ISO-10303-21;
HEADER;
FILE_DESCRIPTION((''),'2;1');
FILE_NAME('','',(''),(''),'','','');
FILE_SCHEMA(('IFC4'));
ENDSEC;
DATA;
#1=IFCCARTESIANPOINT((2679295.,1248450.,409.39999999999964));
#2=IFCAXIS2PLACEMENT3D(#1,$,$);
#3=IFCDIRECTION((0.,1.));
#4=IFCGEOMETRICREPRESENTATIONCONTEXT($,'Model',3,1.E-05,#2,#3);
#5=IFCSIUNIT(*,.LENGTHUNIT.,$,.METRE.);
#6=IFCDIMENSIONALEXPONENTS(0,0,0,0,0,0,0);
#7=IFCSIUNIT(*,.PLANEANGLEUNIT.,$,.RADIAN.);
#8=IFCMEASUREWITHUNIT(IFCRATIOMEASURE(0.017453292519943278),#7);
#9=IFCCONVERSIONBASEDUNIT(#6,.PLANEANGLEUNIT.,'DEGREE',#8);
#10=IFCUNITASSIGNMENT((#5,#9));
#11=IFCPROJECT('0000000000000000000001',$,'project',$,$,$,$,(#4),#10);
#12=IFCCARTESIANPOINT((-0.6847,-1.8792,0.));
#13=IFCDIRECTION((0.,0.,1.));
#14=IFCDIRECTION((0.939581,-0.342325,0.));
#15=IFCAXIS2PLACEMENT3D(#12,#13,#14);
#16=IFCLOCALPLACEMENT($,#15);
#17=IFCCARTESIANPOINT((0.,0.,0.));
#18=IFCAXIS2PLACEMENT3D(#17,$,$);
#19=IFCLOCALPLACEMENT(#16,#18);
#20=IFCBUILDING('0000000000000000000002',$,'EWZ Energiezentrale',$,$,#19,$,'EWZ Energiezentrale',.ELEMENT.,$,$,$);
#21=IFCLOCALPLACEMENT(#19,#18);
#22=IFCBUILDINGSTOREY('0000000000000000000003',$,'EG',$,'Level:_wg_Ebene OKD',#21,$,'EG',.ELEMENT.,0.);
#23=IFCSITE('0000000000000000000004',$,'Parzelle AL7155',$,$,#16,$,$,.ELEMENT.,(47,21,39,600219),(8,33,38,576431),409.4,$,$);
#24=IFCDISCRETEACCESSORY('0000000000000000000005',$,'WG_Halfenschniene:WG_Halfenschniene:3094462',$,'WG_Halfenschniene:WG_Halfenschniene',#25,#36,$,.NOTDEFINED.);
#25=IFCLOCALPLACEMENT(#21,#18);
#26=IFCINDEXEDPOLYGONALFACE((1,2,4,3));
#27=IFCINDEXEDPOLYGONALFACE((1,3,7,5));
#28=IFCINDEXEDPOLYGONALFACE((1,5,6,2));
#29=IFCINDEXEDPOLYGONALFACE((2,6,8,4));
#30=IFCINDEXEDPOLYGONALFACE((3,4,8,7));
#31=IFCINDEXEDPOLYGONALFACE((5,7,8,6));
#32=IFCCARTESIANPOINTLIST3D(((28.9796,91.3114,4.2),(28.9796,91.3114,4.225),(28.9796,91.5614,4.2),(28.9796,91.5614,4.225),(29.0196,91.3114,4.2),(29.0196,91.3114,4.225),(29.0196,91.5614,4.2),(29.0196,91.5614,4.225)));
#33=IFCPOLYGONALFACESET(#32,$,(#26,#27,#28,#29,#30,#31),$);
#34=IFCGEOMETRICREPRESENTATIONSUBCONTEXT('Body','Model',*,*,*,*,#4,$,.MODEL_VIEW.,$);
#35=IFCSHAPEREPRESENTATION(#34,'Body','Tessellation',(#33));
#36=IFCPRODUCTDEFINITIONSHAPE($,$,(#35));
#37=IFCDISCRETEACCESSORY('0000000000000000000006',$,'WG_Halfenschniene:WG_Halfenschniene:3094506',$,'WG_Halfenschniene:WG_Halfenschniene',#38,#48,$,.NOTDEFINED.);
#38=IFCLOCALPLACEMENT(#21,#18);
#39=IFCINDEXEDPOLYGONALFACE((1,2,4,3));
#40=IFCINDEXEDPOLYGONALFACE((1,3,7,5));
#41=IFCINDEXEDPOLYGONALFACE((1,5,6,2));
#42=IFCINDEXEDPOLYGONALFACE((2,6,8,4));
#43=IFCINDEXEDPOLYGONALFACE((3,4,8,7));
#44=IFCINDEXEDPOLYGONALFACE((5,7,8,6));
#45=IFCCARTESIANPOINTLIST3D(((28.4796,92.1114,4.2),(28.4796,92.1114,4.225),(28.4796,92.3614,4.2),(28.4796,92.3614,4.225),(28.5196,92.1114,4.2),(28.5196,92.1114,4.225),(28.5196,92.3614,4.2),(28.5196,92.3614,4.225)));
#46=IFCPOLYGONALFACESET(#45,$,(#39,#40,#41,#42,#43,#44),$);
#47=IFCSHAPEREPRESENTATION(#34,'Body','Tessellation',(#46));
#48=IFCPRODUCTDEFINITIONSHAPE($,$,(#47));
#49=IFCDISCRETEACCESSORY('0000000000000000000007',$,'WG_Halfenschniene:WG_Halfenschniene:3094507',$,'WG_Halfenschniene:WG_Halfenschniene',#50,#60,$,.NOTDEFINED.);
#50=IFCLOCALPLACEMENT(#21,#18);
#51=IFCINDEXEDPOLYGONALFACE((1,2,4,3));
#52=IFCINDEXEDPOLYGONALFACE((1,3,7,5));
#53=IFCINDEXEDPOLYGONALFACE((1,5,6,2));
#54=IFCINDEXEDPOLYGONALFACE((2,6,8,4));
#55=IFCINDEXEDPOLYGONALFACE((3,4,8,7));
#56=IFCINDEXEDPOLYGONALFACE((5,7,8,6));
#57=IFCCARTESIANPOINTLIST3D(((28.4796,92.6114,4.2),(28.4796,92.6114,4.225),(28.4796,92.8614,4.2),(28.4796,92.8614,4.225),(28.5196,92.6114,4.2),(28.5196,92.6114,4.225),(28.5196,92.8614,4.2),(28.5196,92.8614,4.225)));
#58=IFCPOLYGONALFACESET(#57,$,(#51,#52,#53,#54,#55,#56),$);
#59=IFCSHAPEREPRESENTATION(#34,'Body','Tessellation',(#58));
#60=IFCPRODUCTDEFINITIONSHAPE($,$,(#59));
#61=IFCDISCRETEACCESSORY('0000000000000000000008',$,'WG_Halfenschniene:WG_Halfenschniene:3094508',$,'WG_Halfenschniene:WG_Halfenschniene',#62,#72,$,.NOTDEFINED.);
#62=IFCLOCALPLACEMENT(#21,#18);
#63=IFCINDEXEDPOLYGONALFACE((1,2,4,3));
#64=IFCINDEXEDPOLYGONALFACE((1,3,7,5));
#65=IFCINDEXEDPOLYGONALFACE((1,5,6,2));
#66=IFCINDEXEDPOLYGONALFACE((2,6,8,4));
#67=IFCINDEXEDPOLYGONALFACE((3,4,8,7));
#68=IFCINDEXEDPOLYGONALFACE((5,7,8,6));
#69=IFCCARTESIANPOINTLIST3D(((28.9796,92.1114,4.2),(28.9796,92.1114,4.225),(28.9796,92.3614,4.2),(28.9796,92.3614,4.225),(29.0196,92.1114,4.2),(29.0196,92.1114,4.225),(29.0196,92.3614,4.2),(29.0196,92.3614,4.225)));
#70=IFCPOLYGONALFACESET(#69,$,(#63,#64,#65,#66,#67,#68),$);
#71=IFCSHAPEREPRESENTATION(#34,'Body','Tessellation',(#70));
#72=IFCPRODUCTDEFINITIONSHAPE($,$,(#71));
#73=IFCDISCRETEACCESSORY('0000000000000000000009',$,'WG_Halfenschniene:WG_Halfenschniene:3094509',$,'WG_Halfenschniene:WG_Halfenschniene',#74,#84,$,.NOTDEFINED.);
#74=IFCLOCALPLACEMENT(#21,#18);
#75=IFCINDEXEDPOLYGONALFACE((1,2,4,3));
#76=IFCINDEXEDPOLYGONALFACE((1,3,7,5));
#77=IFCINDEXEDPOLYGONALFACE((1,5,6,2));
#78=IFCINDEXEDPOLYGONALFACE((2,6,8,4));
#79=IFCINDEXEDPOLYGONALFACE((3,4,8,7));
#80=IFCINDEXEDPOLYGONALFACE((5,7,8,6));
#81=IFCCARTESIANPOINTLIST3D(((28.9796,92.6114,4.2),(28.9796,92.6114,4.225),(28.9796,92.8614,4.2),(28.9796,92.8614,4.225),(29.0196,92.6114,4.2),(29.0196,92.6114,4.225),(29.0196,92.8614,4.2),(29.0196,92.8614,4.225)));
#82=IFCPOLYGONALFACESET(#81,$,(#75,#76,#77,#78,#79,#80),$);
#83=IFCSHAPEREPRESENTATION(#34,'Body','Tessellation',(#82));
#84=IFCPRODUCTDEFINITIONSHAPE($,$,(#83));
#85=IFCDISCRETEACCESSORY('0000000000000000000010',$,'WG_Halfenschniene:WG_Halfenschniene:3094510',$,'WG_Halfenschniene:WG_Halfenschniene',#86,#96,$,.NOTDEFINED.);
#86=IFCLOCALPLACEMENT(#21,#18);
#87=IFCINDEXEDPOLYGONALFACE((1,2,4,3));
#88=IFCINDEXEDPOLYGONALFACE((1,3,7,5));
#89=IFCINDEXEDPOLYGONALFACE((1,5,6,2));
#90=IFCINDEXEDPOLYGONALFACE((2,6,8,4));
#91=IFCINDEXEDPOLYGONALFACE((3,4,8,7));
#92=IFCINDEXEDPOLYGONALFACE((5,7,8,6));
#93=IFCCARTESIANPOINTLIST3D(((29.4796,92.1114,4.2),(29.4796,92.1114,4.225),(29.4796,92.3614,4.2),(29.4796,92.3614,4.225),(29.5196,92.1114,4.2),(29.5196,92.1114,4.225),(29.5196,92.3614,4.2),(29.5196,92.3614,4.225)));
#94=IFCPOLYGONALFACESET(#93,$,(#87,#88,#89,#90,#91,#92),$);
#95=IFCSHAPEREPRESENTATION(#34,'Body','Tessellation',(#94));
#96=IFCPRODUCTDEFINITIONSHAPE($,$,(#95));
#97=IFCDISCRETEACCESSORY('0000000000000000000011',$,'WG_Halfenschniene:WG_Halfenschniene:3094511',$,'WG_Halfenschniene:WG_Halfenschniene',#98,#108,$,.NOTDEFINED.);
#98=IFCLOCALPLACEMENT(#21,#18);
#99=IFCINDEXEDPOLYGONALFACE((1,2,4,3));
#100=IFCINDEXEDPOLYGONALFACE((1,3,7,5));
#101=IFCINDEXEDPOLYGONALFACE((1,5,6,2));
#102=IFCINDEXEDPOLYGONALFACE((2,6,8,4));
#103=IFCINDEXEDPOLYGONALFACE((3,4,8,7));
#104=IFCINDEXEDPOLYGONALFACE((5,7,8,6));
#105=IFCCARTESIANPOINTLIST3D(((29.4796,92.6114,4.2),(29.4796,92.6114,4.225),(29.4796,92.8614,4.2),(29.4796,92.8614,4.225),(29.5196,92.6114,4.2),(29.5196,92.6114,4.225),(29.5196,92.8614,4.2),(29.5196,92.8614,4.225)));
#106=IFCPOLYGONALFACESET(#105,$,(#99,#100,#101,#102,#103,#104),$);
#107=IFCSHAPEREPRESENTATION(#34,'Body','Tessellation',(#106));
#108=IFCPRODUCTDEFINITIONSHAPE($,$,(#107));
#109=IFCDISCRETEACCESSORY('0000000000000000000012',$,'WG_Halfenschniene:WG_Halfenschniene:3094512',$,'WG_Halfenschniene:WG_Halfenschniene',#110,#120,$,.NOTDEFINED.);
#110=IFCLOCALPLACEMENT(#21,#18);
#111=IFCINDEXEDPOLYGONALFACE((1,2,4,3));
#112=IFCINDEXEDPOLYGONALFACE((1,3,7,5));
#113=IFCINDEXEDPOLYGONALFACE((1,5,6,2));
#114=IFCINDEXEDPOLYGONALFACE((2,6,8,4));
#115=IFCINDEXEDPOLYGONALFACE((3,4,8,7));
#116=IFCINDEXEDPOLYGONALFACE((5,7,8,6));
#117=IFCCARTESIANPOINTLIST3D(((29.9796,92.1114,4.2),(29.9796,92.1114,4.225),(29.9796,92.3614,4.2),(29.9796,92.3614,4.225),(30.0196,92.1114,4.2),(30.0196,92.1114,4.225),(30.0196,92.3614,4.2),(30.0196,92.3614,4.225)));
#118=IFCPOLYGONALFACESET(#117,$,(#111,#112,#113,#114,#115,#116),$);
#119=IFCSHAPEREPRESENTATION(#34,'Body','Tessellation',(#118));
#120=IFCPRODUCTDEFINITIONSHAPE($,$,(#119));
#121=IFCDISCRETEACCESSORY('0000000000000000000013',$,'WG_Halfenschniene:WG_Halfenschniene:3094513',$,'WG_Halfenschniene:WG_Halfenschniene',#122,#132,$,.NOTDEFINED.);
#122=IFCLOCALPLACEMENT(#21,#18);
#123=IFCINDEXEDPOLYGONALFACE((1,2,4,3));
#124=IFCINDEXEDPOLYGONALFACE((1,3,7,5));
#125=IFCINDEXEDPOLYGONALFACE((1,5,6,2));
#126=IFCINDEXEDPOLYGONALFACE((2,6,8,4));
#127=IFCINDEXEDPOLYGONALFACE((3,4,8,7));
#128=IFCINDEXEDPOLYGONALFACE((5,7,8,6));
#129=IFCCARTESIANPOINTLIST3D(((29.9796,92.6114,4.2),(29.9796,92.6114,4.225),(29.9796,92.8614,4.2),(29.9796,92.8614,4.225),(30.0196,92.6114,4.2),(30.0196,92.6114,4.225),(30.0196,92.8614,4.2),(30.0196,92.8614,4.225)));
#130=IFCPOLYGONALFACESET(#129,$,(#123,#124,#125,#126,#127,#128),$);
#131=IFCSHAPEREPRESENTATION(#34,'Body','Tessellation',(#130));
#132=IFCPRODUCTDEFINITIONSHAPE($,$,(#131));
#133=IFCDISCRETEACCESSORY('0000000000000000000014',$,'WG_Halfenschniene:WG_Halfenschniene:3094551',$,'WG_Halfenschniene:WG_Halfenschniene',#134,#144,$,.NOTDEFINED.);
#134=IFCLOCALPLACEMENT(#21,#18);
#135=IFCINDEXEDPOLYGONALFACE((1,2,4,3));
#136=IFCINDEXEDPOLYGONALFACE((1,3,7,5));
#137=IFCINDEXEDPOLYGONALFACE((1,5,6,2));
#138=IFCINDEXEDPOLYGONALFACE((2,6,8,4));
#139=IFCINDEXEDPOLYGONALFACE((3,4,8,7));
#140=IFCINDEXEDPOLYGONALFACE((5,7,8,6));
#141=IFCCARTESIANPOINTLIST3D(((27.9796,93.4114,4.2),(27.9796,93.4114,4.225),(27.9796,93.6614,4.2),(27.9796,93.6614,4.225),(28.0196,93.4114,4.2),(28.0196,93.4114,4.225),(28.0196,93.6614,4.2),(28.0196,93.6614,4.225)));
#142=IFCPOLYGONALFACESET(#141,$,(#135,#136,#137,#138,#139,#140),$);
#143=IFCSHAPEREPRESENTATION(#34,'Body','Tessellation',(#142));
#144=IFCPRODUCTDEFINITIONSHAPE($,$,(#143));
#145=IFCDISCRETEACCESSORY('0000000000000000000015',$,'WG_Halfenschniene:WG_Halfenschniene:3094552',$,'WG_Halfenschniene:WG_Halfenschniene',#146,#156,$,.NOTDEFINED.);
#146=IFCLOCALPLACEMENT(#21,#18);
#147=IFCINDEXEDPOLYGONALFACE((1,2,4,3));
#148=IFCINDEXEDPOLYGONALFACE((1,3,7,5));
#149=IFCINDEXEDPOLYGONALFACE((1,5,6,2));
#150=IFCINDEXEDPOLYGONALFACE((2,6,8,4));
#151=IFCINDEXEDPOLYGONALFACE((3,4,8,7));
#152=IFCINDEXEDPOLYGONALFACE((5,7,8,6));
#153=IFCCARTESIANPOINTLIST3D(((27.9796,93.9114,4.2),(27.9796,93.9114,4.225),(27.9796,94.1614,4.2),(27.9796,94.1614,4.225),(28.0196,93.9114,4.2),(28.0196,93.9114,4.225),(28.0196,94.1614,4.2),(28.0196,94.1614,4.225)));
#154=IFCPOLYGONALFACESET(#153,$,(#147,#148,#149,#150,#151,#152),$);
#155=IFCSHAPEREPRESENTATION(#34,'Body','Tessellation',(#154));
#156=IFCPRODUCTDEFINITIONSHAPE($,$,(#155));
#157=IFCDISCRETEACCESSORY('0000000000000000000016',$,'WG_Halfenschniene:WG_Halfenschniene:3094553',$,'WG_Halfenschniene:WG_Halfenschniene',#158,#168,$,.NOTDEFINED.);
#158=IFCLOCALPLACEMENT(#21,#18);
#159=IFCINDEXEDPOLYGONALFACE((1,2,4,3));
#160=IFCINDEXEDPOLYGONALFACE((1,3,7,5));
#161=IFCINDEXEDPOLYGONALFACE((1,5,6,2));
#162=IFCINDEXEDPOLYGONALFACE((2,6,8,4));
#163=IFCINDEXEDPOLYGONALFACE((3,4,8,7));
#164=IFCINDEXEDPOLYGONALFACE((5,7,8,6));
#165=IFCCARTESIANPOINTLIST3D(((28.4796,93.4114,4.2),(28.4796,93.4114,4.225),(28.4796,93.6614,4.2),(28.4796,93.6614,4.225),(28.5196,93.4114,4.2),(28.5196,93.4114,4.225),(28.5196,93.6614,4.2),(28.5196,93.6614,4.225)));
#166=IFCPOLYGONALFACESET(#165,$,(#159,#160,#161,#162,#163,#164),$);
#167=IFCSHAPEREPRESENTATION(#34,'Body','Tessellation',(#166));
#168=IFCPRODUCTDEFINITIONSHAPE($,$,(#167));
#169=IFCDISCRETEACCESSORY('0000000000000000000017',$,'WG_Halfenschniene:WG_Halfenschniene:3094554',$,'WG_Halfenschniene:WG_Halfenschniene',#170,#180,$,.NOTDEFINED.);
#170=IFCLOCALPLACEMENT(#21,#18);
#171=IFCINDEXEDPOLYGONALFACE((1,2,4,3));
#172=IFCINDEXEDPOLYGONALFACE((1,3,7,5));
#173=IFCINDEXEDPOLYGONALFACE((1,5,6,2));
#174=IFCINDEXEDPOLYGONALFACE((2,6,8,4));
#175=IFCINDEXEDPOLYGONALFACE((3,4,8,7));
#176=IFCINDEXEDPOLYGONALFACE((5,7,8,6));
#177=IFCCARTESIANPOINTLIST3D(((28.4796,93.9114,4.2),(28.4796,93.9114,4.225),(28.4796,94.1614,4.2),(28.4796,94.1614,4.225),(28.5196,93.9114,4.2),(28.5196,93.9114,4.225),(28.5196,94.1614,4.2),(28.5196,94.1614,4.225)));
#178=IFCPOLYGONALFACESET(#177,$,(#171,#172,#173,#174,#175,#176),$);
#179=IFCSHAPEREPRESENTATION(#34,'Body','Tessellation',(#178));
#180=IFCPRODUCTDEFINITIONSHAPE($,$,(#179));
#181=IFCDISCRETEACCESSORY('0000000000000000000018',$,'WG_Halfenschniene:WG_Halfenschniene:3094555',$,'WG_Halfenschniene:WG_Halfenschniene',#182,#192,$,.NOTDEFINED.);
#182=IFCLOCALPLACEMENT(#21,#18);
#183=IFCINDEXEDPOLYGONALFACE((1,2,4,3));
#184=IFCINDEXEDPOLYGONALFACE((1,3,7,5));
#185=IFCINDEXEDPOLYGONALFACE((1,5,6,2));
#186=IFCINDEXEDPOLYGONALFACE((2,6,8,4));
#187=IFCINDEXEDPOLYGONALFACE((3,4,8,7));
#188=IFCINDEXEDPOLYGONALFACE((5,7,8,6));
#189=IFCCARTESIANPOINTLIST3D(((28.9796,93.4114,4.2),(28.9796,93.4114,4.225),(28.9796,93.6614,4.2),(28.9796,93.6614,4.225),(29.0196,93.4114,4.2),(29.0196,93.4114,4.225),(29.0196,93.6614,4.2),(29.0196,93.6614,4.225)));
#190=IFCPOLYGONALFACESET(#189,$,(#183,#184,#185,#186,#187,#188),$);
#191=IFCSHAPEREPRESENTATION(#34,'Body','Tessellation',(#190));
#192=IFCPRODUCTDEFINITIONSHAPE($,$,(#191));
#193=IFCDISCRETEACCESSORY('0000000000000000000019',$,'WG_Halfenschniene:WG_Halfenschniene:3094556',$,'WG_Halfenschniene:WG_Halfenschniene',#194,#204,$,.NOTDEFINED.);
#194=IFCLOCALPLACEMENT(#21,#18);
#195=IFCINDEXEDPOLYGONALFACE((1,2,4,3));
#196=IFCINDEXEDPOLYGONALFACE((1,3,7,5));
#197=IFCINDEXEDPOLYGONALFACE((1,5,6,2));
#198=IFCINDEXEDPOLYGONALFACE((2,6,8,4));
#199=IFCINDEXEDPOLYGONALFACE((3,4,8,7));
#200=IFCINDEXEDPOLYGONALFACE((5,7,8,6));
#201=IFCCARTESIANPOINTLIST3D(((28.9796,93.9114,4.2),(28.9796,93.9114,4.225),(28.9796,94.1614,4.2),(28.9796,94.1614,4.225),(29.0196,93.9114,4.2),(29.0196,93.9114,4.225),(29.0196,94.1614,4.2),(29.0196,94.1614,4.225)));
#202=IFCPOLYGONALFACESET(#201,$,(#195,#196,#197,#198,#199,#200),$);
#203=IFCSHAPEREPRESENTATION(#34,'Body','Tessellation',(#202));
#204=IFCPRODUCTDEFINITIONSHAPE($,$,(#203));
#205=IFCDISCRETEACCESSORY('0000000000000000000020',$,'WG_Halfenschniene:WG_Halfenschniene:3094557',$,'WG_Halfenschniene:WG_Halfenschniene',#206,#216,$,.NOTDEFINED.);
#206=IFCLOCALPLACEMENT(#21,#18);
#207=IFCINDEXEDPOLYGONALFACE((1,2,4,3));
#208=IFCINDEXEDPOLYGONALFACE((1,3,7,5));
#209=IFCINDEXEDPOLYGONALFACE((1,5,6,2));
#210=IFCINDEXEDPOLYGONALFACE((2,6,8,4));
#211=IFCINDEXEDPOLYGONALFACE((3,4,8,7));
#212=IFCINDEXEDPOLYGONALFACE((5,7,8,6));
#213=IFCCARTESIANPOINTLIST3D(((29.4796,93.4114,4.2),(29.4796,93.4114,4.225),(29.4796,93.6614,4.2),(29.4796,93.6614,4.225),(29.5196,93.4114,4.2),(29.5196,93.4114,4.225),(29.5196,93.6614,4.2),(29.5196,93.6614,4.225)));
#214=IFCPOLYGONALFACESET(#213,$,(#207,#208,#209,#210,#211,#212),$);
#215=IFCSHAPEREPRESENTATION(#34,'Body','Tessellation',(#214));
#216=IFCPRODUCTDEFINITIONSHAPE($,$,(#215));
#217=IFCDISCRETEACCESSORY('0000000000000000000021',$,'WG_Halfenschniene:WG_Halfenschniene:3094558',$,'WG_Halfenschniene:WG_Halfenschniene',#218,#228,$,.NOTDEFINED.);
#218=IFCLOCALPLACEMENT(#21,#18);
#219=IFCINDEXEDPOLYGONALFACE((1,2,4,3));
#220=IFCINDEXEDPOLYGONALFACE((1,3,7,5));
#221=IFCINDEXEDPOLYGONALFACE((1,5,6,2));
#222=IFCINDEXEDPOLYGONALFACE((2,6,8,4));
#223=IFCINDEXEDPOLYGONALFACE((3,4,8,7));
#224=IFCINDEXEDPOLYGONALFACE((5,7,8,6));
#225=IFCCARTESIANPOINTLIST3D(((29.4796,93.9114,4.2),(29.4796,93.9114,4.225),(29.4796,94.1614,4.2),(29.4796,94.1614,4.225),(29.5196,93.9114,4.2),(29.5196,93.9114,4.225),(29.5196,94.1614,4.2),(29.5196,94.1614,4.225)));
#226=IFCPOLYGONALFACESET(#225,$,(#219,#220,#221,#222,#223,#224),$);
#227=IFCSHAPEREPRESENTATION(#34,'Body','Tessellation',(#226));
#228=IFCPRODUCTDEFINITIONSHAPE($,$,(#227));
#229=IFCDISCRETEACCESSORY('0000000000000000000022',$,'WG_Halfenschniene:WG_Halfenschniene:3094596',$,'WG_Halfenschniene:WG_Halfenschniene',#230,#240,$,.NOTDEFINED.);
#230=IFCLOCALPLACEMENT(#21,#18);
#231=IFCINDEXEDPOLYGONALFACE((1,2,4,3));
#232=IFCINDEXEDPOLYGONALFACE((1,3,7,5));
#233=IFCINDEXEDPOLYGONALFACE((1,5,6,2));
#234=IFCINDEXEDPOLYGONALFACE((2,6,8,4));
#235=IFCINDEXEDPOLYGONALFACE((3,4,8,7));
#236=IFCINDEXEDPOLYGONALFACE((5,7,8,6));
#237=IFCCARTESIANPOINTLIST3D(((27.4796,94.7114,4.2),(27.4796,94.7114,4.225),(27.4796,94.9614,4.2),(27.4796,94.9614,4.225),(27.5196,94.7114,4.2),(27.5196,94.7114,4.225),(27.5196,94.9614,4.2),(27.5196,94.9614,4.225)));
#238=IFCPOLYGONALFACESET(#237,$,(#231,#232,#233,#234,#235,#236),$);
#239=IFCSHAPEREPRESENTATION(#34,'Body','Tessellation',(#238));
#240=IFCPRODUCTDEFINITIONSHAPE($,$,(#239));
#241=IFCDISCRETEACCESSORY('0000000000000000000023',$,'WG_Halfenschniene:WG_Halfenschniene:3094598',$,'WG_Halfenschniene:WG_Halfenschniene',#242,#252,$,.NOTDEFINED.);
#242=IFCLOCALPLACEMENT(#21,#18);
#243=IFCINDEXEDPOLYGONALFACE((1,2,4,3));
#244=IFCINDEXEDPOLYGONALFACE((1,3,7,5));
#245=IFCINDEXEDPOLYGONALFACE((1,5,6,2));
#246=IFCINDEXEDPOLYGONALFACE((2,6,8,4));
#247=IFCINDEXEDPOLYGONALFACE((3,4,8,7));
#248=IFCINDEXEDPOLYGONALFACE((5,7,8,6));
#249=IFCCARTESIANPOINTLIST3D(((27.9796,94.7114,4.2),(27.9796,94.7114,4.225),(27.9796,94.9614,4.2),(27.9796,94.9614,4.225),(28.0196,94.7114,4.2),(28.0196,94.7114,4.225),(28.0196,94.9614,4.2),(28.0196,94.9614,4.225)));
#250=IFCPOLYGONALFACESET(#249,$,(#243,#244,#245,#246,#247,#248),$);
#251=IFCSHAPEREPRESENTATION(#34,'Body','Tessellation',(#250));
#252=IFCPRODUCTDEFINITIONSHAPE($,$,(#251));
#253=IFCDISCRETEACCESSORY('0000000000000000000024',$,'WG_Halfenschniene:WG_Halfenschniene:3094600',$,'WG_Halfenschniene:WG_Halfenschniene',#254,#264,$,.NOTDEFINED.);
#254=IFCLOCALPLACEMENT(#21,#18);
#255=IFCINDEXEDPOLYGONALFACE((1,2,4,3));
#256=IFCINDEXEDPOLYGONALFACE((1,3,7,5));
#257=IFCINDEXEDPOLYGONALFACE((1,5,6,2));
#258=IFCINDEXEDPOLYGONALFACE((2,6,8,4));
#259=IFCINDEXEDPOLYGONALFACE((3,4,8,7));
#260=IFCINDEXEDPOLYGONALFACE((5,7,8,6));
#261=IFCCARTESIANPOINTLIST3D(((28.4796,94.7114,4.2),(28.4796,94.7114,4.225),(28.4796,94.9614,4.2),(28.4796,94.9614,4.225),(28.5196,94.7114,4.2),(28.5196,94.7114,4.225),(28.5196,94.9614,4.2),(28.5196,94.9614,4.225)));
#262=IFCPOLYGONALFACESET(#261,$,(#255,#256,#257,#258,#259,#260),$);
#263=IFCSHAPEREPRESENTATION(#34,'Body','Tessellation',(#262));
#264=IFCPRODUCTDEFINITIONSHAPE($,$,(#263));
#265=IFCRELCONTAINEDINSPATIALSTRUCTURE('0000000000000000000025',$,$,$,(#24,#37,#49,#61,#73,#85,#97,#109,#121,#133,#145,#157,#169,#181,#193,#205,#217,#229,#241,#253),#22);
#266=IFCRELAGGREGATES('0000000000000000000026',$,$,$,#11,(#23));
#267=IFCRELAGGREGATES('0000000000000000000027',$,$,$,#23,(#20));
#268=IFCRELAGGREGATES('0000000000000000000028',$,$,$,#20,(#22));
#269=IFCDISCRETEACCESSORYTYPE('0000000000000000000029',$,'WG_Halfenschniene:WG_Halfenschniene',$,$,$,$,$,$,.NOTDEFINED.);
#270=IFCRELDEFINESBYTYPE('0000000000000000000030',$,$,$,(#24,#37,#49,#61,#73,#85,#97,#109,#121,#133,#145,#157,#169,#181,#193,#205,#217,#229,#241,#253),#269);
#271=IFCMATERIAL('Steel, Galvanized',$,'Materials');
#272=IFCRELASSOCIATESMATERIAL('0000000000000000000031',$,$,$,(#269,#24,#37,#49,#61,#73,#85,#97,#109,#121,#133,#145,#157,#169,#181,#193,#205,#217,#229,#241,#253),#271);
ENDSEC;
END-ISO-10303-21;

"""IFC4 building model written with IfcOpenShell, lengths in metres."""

from ifc_helpers import new_model, entity, si_unit, converted_unit, direction, frame, origin, place, context, subcontext, project, spatial, indexed_curve, outline, extrude, source, transform, mapped, material, type_object, element, save


model = new_model("IFC4")

# Units and contexts
model_context = context("Model", 3, precision=1e-05, world=frame((2679295.0, 1248450.0, 409.39999999999964)), true_north=direction((0.0, 1.0)))
body_context = subcontext(model_context, "Body", "Model", "MODEL_VIEW")
ifc_project = project(units=[si_unit("LENGTHUNIT", "METRE"), converted_unit("PLANEANGLEUNIT", "DEGREE", entity("IfcRatioMeasure", 0.017453292519943278), si_unit("PLANEANGLEUNIT", "RADIAN"), dimensions=[0, 0, 0, 0, 0, 0, 0])], contexts=[model_context])

# Site, building, storey
site_placement = place(None, frame((-0.6847, -1.8792, 0.0), z_axis=(0.0, 0.0, 1.0), x_axis=(0.939581, -0.342325, 0.0)))
site = spatial("IfcSite", under=ifc_project, at=site_placement, Name="Parzelle AL7155", CompositionType="ELEMENT", RefLatitude=(47, 21, 39, 600219), RefLongitude=(8, 33, 38, 576431), RefElevation=409.4)
building_placement = place(site_placement, origin())
building = spatial("IfcBuilding", under=site, at=building_placement, Name="EWZ Energiezentrale", LongName="EWZ Energiezentrale", CompositionType="ELEMENT")
storey_placement = place(building_placement, origin())
storey = spatial("IfcBuildingStorey", under=building, at=storey_placement, Name="EG", ObjectType="Level:_wg_Ebene OKD", LongName="EG", CompositionType="ELEMENT", Elevation=0.0)

# Discrete accessories
ifc_material = material(Name="Steel, Galvanized", Category="Materials")
discrete_accessory_type = type_object("IfcDiscreteAccessoryType", Name="WG_Halfenschniene:WG_Halfenschniene", PredefinedType="NOTDEFINED", material=ifc_material)
shared_shape = source(origin(), body_context, "Body", "SweptSolid", [
    extrude(outline(indexed_curve([(-0.125, -0.02), (0.125, -0.02), (0.125, 0.02), (-0.125, 0.02), (-0.125, -0.02)], self_intersect=False)), frame((0.125, 0.0, -0.0125)), (0.0, 0.0, 1.0), 0.025),
])
for number, where, z_axis, x_axis, name in (
    (1, (28.9996, 91.3114, 4.2125), (0.0, 0.0, -1.0), (0.0, 1.0, 0.0), "WG_Halfenschniene:WG_Halfenschniene:3094462"),
    (2, (28.4996, 92.1114, 4.2125), (0.0, 0.0, -1.0), (0.0, 1.0, 0.0), "WG_Halfenschniene:WG_Halfenschniene:3094506"),
    (3, (28.4996, 92.6114, 4.2125), (0.0, 0.0, -1.0), (0.0, 1.0, 0.0), "WG_Halfenschniene:WG_Halfenschniene:3094507"),
    (4, (28.9996, 92.1114, 4.2125), (0.0, 0.0, -1.0), (0.0, 1.0, 0.0), "WG_Halfenschniene:WG_Halfenschniene:3094508"),
    (5, (28.9996, 92.6114, 4.2125), (0.0, 0.0, -1.0), (0.0, 1.0, 0.0), "WG_Halfenschniene:WG_Halfenschniene:3094509"),
    (6, (29.4996, 92.1114, 4.2125), (0.0, 0.0, -1.0), (0.0, 1.0, 0.0), "WG_Halfenschniene:WG_Halfenschniene:3094510"),
    (7, (29.4996, 92.6114, 4.2125), (0.0, 0.0, -1.0), (0.0, 1.0, 0.0), "WG_Halfenschniene:WG_Halfenschniene:3094511"),
    (8, (29.9996, 92.1114, 4.2125), (0.0, 0.0, -1.0), (0.0, 1.0, 0.0), "WG_Halfenschniene:WG_Halfenschniene:3094512"),
    (9, (29.9996, 92.6114, 4.2125), (0.0, 0.0, -1.0), (0.0, 1.0, 0.0), "WG_Halfenschniene:WG_Halfenschniene:3094513"),
    (10, (27.9996, 93.4114, 4.2125), (0.0, 0.0, -1.0), (0.0, 1.0, 0.0), "WG_Halfenschniene:WG_Halfenschniene:3094551"),
    (11, (27.9996, 93.9114, 4.2125), (0.0, 0.0, -1.0), (0.0, 1.0, 0.0), "WG_Halfenschniene:WG_Halfenschniene:3094552"),
    (12, (28.4996, 93.4114, 4.2125), (0.0, 0.0, -1.0), (0.0, 1.0, 0.0), "WG_Halfenschniene:WG_Halfenschniene:3094553"),
    (13, (28.4996, 93.9114, 4.2125), (0.0, 0.0, -1.0), (0.0, 1.0, 0.0), "WG_Halfenschniene:WG_Halfenschniene:3094554"),
    (14, (28.9996, 93.4114, 4.2125), (0.0, 0.0, -1.0), (0.0, 1.0, 0.0), "WG_Halfenschniene:WG_Halfenschniene:3094555"),
    (15, (28.9996, 93.9114, 4.2125), (0.0, 0.0, -1.0), (0.0, 1.0, 0.0), "WG_Halfenschniene:WG_Halfenschniene:3094556"),
    (16, (29.4996, 93.4114, 4.2125), (0.0, 0.0, -1.0), (0.0, 1.0, 0.0), "WG_Halfenschniene:WG_Halfenschniene:3094557"),
    (17, (29.4996, 93.9114, 4.2125), (0.0, 0.0, -1.0), (0.0, 1.0, 0.0), "WG_Halfenschniene:WG_Halfenschniene:3094558"),
    (18, (27.4996, 94.7114, 4.2125), (0.0, 0.0, -1.0), (0.0, 1.0, 0.0), "WG_Halfenschniene:WG_Halfenschniene:3094596"),
    (19, (27.9996, 94.7114, 4.2125), (0.0, 0.0, -1.0), (0.0, 1.0, 0.0), "WG_Halfenschniene:WG_Halfenschniene:3094598"),
    (20, (28.4996, 94.7114, 4.2125), (0.0, 0.0, -1.0), (0.0, 1.0, 0.0), "WG_Halfenschniene:WG_Halfenschniene:3094600"),
):
    element("IfcDiscreteAccessory", number, at=place(storey_placement, frame(where, z_axis=z_axis, x_axis=x_axis)), inside=storey, type_object=discrete_accessory_type, material=ifc_material, Name=name, ObjectType="WG_Halfenschniene:WG_Halfenschniene", PredefinedType="NOTDEFINED", context=body_context, shape_type="MappedRepresentation", body=[
        mapped(shared_shape, transform((0.0, 0.0, 0.0), scale=1.0)),
    ])

save(model, "model.ifc")
